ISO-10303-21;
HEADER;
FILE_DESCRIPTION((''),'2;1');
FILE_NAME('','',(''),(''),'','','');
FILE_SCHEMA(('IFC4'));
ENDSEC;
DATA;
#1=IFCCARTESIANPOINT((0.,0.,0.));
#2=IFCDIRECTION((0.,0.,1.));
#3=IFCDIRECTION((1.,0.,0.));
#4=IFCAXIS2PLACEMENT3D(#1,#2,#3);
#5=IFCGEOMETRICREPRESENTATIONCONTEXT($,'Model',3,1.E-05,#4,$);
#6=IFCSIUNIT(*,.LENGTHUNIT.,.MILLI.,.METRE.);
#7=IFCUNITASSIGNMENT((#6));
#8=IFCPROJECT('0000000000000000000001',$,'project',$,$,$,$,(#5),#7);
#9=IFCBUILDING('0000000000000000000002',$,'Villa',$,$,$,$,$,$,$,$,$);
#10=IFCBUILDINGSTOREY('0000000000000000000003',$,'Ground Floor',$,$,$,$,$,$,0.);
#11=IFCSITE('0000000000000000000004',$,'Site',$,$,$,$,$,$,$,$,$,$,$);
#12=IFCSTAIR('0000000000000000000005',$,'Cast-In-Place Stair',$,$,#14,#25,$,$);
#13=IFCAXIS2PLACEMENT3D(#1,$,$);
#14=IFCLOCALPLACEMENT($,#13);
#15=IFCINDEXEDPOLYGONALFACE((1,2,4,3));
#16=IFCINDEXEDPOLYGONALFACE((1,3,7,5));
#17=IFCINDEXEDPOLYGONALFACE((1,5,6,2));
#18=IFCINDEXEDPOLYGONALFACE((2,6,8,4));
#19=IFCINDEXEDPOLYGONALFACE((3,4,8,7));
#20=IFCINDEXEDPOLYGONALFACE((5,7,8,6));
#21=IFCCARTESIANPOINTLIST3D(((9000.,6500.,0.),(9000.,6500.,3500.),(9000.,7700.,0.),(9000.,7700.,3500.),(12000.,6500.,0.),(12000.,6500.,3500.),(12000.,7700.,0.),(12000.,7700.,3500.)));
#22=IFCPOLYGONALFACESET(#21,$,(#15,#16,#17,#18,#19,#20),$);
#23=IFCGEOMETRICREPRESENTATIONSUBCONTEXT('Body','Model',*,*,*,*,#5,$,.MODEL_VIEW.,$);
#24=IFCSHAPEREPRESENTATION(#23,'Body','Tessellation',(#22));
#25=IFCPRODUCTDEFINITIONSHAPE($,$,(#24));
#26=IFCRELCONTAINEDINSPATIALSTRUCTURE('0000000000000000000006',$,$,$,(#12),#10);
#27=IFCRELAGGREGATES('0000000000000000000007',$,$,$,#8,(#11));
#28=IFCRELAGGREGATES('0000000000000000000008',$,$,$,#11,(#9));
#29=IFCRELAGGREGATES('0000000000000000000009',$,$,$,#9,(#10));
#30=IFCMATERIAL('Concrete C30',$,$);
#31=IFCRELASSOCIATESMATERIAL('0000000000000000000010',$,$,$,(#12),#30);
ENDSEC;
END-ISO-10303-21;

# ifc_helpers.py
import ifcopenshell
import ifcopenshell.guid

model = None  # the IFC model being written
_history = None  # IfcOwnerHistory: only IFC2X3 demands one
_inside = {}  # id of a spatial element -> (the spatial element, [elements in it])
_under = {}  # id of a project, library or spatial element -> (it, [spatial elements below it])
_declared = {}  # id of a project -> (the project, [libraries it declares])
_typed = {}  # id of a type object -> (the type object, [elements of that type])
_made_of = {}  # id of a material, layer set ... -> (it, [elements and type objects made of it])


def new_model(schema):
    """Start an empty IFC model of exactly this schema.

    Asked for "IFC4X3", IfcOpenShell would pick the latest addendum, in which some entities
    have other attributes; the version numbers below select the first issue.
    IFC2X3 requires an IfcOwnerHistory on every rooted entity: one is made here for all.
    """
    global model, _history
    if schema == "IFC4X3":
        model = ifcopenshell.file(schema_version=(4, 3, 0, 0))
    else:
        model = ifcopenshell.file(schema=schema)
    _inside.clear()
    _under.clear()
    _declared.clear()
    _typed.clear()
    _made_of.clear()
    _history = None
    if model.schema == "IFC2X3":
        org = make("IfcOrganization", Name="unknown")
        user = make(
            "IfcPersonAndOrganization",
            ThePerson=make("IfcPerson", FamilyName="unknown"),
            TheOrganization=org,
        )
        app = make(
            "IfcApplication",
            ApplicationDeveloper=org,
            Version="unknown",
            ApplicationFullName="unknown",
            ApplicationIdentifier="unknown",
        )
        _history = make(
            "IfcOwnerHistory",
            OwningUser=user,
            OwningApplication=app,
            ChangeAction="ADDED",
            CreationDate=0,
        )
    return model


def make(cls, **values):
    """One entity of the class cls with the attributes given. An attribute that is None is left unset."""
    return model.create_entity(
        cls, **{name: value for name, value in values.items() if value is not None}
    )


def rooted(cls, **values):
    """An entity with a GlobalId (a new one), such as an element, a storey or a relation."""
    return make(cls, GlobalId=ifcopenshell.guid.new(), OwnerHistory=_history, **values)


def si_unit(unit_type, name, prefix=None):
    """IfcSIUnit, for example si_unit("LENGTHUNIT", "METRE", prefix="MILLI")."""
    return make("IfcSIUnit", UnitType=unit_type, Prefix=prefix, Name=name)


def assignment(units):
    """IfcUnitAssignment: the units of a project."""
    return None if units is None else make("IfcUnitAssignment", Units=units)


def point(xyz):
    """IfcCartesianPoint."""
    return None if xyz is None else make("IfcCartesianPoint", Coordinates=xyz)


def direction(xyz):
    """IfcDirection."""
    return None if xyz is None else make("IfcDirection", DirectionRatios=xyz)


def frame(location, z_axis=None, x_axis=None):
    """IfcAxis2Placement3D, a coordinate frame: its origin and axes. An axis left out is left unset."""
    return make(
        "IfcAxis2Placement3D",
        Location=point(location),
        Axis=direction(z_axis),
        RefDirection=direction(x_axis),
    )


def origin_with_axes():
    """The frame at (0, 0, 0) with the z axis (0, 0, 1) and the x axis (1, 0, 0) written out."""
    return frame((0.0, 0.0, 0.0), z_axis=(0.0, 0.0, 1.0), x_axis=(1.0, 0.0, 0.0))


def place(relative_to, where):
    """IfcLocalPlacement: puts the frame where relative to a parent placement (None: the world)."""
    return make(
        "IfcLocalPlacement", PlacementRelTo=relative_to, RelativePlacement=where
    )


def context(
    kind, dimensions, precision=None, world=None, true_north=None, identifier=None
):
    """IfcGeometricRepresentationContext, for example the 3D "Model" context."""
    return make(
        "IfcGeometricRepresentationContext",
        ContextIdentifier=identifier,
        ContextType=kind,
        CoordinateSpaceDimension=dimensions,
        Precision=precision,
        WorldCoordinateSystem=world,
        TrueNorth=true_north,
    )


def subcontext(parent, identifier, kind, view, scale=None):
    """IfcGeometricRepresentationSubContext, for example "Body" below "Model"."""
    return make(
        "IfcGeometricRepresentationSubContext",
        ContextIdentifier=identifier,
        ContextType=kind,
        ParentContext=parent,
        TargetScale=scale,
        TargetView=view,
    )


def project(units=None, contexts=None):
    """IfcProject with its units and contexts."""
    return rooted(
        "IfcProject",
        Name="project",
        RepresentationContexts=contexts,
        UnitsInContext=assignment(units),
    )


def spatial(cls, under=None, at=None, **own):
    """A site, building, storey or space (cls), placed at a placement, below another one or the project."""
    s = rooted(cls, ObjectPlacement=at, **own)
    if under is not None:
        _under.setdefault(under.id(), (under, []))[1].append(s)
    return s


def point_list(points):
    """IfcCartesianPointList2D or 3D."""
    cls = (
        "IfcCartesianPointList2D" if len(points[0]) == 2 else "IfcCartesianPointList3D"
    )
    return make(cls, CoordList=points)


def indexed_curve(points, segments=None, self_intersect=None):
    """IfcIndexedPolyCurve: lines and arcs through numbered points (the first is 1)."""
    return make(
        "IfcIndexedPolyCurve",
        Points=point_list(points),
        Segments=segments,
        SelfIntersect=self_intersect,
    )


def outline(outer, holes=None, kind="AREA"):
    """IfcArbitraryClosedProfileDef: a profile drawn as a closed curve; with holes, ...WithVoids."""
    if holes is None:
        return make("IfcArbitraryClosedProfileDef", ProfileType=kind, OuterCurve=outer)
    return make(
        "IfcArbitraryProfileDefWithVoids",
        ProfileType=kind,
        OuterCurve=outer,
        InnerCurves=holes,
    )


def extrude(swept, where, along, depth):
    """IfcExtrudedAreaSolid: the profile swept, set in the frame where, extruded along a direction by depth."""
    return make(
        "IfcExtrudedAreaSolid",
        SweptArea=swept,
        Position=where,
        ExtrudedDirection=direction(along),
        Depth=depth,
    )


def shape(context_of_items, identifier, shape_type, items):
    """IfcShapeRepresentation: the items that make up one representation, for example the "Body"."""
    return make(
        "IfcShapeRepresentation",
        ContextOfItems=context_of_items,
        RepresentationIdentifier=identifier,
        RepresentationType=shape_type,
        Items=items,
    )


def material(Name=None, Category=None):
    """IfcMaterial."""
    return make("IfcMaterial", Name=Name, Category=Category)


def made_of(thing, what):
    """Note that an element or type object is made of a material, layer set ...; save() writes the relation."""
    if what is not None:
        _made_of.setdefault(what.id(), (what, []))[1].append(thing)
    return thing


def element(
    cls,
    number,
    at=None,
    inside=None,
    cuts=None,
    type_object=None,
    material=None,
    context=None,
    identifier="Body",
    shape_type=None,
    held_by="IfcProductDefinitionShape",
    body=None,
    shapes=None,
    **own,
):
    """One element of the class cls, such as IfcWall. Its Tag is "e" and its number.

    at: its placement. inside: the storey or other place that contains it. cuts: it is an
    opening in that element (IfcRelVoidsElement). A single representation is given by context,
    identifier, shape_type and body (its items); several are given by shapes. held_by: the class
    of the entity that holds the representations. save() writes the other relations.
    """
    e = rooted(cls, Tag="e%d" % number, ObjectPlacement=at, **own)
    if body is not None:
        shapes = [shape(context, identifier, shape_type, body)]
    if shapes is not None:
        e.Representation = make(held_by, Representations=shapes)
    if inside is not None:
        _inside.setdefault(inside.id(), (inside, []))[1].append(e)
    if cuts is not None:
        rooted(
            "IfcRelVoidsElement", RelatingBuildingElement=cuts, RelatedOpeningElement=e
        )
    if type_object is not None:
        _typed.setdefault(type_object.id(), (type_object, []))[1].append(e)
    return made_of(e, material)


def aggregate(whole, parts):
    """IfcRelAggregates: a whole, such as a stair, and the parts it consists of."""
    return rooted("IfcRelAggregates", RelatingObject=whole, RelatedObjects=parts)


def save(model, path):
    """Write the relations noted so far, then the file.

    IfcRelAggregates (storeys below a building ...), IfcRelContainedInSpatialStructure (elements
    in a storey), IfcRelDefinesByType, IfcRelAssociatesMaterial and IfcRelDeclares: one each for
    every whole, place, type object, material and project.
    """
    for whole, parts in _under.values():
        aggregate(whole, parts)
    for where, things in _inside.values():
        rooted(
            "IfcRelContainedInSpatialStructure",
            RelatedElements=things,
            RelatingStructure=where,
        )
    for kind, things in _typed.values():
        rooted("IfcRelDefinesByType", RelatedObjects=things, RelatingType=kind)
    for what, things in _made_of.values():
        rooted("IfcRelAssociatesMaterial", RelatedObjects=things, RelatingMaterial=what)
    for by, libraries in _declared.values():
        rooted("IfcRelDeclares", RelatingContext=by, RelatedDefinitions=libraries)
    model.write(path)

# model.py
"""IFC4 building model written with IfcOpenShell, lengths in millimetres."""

from ifc_helpers import new_model, si_unit, frame, origin_with_axes, place, context, subcontext, project, spatial, indexed_curve, outline, extrude, material, element, save


model = new_model("IFC4")

# Units and contexts
model_context = context("Model", 3, precision=1e-05, world=origin_with_axes())
body_context = subcontext(model_context, "Body", "Model", "MODEL_VIEW")
ifc_project = project(units=[si_unit("LENGTHUNIT", "METRE", prefix="MILLI")], contexts=[model_context])

# Site, building, storey
site = spatial("IfcSite", under=ifc_project, Name="Site")
building = spatial("IfcBuilding", under=site, Name="Villa")
storey = spatial("IfcBuildingStorey", under=building, Name="Ground Floor", Elevation=0.0)

# Shared definitions
ifc_material_1 = material(Name="Concrete C30")

# Stair
stair_placement = place(None, frame((9000.0, 6500.0, 0.0), z_axis=(0.0, 0.0, 1.0), x_axis=(1.0, 0.0, 0.0)))
element("IfcStair", 1, at=stair_placement, inside=storey, material=ifc_material_1, Name="Cast-In-Place Stair", context=body_context, shape_type="SweptSolid", body=[
    extrude(outline(indexed_curve([(0.0, 0.0), (0.0, 1200.0), (3000.0, 1200.0), (3000.0, 0.0), (0.0, 0.0)], self_intersect=False)), origin_with_axes(), (0.0, 0.0, 1.0), 3500.0),
])

save(model, "model.ifc")
